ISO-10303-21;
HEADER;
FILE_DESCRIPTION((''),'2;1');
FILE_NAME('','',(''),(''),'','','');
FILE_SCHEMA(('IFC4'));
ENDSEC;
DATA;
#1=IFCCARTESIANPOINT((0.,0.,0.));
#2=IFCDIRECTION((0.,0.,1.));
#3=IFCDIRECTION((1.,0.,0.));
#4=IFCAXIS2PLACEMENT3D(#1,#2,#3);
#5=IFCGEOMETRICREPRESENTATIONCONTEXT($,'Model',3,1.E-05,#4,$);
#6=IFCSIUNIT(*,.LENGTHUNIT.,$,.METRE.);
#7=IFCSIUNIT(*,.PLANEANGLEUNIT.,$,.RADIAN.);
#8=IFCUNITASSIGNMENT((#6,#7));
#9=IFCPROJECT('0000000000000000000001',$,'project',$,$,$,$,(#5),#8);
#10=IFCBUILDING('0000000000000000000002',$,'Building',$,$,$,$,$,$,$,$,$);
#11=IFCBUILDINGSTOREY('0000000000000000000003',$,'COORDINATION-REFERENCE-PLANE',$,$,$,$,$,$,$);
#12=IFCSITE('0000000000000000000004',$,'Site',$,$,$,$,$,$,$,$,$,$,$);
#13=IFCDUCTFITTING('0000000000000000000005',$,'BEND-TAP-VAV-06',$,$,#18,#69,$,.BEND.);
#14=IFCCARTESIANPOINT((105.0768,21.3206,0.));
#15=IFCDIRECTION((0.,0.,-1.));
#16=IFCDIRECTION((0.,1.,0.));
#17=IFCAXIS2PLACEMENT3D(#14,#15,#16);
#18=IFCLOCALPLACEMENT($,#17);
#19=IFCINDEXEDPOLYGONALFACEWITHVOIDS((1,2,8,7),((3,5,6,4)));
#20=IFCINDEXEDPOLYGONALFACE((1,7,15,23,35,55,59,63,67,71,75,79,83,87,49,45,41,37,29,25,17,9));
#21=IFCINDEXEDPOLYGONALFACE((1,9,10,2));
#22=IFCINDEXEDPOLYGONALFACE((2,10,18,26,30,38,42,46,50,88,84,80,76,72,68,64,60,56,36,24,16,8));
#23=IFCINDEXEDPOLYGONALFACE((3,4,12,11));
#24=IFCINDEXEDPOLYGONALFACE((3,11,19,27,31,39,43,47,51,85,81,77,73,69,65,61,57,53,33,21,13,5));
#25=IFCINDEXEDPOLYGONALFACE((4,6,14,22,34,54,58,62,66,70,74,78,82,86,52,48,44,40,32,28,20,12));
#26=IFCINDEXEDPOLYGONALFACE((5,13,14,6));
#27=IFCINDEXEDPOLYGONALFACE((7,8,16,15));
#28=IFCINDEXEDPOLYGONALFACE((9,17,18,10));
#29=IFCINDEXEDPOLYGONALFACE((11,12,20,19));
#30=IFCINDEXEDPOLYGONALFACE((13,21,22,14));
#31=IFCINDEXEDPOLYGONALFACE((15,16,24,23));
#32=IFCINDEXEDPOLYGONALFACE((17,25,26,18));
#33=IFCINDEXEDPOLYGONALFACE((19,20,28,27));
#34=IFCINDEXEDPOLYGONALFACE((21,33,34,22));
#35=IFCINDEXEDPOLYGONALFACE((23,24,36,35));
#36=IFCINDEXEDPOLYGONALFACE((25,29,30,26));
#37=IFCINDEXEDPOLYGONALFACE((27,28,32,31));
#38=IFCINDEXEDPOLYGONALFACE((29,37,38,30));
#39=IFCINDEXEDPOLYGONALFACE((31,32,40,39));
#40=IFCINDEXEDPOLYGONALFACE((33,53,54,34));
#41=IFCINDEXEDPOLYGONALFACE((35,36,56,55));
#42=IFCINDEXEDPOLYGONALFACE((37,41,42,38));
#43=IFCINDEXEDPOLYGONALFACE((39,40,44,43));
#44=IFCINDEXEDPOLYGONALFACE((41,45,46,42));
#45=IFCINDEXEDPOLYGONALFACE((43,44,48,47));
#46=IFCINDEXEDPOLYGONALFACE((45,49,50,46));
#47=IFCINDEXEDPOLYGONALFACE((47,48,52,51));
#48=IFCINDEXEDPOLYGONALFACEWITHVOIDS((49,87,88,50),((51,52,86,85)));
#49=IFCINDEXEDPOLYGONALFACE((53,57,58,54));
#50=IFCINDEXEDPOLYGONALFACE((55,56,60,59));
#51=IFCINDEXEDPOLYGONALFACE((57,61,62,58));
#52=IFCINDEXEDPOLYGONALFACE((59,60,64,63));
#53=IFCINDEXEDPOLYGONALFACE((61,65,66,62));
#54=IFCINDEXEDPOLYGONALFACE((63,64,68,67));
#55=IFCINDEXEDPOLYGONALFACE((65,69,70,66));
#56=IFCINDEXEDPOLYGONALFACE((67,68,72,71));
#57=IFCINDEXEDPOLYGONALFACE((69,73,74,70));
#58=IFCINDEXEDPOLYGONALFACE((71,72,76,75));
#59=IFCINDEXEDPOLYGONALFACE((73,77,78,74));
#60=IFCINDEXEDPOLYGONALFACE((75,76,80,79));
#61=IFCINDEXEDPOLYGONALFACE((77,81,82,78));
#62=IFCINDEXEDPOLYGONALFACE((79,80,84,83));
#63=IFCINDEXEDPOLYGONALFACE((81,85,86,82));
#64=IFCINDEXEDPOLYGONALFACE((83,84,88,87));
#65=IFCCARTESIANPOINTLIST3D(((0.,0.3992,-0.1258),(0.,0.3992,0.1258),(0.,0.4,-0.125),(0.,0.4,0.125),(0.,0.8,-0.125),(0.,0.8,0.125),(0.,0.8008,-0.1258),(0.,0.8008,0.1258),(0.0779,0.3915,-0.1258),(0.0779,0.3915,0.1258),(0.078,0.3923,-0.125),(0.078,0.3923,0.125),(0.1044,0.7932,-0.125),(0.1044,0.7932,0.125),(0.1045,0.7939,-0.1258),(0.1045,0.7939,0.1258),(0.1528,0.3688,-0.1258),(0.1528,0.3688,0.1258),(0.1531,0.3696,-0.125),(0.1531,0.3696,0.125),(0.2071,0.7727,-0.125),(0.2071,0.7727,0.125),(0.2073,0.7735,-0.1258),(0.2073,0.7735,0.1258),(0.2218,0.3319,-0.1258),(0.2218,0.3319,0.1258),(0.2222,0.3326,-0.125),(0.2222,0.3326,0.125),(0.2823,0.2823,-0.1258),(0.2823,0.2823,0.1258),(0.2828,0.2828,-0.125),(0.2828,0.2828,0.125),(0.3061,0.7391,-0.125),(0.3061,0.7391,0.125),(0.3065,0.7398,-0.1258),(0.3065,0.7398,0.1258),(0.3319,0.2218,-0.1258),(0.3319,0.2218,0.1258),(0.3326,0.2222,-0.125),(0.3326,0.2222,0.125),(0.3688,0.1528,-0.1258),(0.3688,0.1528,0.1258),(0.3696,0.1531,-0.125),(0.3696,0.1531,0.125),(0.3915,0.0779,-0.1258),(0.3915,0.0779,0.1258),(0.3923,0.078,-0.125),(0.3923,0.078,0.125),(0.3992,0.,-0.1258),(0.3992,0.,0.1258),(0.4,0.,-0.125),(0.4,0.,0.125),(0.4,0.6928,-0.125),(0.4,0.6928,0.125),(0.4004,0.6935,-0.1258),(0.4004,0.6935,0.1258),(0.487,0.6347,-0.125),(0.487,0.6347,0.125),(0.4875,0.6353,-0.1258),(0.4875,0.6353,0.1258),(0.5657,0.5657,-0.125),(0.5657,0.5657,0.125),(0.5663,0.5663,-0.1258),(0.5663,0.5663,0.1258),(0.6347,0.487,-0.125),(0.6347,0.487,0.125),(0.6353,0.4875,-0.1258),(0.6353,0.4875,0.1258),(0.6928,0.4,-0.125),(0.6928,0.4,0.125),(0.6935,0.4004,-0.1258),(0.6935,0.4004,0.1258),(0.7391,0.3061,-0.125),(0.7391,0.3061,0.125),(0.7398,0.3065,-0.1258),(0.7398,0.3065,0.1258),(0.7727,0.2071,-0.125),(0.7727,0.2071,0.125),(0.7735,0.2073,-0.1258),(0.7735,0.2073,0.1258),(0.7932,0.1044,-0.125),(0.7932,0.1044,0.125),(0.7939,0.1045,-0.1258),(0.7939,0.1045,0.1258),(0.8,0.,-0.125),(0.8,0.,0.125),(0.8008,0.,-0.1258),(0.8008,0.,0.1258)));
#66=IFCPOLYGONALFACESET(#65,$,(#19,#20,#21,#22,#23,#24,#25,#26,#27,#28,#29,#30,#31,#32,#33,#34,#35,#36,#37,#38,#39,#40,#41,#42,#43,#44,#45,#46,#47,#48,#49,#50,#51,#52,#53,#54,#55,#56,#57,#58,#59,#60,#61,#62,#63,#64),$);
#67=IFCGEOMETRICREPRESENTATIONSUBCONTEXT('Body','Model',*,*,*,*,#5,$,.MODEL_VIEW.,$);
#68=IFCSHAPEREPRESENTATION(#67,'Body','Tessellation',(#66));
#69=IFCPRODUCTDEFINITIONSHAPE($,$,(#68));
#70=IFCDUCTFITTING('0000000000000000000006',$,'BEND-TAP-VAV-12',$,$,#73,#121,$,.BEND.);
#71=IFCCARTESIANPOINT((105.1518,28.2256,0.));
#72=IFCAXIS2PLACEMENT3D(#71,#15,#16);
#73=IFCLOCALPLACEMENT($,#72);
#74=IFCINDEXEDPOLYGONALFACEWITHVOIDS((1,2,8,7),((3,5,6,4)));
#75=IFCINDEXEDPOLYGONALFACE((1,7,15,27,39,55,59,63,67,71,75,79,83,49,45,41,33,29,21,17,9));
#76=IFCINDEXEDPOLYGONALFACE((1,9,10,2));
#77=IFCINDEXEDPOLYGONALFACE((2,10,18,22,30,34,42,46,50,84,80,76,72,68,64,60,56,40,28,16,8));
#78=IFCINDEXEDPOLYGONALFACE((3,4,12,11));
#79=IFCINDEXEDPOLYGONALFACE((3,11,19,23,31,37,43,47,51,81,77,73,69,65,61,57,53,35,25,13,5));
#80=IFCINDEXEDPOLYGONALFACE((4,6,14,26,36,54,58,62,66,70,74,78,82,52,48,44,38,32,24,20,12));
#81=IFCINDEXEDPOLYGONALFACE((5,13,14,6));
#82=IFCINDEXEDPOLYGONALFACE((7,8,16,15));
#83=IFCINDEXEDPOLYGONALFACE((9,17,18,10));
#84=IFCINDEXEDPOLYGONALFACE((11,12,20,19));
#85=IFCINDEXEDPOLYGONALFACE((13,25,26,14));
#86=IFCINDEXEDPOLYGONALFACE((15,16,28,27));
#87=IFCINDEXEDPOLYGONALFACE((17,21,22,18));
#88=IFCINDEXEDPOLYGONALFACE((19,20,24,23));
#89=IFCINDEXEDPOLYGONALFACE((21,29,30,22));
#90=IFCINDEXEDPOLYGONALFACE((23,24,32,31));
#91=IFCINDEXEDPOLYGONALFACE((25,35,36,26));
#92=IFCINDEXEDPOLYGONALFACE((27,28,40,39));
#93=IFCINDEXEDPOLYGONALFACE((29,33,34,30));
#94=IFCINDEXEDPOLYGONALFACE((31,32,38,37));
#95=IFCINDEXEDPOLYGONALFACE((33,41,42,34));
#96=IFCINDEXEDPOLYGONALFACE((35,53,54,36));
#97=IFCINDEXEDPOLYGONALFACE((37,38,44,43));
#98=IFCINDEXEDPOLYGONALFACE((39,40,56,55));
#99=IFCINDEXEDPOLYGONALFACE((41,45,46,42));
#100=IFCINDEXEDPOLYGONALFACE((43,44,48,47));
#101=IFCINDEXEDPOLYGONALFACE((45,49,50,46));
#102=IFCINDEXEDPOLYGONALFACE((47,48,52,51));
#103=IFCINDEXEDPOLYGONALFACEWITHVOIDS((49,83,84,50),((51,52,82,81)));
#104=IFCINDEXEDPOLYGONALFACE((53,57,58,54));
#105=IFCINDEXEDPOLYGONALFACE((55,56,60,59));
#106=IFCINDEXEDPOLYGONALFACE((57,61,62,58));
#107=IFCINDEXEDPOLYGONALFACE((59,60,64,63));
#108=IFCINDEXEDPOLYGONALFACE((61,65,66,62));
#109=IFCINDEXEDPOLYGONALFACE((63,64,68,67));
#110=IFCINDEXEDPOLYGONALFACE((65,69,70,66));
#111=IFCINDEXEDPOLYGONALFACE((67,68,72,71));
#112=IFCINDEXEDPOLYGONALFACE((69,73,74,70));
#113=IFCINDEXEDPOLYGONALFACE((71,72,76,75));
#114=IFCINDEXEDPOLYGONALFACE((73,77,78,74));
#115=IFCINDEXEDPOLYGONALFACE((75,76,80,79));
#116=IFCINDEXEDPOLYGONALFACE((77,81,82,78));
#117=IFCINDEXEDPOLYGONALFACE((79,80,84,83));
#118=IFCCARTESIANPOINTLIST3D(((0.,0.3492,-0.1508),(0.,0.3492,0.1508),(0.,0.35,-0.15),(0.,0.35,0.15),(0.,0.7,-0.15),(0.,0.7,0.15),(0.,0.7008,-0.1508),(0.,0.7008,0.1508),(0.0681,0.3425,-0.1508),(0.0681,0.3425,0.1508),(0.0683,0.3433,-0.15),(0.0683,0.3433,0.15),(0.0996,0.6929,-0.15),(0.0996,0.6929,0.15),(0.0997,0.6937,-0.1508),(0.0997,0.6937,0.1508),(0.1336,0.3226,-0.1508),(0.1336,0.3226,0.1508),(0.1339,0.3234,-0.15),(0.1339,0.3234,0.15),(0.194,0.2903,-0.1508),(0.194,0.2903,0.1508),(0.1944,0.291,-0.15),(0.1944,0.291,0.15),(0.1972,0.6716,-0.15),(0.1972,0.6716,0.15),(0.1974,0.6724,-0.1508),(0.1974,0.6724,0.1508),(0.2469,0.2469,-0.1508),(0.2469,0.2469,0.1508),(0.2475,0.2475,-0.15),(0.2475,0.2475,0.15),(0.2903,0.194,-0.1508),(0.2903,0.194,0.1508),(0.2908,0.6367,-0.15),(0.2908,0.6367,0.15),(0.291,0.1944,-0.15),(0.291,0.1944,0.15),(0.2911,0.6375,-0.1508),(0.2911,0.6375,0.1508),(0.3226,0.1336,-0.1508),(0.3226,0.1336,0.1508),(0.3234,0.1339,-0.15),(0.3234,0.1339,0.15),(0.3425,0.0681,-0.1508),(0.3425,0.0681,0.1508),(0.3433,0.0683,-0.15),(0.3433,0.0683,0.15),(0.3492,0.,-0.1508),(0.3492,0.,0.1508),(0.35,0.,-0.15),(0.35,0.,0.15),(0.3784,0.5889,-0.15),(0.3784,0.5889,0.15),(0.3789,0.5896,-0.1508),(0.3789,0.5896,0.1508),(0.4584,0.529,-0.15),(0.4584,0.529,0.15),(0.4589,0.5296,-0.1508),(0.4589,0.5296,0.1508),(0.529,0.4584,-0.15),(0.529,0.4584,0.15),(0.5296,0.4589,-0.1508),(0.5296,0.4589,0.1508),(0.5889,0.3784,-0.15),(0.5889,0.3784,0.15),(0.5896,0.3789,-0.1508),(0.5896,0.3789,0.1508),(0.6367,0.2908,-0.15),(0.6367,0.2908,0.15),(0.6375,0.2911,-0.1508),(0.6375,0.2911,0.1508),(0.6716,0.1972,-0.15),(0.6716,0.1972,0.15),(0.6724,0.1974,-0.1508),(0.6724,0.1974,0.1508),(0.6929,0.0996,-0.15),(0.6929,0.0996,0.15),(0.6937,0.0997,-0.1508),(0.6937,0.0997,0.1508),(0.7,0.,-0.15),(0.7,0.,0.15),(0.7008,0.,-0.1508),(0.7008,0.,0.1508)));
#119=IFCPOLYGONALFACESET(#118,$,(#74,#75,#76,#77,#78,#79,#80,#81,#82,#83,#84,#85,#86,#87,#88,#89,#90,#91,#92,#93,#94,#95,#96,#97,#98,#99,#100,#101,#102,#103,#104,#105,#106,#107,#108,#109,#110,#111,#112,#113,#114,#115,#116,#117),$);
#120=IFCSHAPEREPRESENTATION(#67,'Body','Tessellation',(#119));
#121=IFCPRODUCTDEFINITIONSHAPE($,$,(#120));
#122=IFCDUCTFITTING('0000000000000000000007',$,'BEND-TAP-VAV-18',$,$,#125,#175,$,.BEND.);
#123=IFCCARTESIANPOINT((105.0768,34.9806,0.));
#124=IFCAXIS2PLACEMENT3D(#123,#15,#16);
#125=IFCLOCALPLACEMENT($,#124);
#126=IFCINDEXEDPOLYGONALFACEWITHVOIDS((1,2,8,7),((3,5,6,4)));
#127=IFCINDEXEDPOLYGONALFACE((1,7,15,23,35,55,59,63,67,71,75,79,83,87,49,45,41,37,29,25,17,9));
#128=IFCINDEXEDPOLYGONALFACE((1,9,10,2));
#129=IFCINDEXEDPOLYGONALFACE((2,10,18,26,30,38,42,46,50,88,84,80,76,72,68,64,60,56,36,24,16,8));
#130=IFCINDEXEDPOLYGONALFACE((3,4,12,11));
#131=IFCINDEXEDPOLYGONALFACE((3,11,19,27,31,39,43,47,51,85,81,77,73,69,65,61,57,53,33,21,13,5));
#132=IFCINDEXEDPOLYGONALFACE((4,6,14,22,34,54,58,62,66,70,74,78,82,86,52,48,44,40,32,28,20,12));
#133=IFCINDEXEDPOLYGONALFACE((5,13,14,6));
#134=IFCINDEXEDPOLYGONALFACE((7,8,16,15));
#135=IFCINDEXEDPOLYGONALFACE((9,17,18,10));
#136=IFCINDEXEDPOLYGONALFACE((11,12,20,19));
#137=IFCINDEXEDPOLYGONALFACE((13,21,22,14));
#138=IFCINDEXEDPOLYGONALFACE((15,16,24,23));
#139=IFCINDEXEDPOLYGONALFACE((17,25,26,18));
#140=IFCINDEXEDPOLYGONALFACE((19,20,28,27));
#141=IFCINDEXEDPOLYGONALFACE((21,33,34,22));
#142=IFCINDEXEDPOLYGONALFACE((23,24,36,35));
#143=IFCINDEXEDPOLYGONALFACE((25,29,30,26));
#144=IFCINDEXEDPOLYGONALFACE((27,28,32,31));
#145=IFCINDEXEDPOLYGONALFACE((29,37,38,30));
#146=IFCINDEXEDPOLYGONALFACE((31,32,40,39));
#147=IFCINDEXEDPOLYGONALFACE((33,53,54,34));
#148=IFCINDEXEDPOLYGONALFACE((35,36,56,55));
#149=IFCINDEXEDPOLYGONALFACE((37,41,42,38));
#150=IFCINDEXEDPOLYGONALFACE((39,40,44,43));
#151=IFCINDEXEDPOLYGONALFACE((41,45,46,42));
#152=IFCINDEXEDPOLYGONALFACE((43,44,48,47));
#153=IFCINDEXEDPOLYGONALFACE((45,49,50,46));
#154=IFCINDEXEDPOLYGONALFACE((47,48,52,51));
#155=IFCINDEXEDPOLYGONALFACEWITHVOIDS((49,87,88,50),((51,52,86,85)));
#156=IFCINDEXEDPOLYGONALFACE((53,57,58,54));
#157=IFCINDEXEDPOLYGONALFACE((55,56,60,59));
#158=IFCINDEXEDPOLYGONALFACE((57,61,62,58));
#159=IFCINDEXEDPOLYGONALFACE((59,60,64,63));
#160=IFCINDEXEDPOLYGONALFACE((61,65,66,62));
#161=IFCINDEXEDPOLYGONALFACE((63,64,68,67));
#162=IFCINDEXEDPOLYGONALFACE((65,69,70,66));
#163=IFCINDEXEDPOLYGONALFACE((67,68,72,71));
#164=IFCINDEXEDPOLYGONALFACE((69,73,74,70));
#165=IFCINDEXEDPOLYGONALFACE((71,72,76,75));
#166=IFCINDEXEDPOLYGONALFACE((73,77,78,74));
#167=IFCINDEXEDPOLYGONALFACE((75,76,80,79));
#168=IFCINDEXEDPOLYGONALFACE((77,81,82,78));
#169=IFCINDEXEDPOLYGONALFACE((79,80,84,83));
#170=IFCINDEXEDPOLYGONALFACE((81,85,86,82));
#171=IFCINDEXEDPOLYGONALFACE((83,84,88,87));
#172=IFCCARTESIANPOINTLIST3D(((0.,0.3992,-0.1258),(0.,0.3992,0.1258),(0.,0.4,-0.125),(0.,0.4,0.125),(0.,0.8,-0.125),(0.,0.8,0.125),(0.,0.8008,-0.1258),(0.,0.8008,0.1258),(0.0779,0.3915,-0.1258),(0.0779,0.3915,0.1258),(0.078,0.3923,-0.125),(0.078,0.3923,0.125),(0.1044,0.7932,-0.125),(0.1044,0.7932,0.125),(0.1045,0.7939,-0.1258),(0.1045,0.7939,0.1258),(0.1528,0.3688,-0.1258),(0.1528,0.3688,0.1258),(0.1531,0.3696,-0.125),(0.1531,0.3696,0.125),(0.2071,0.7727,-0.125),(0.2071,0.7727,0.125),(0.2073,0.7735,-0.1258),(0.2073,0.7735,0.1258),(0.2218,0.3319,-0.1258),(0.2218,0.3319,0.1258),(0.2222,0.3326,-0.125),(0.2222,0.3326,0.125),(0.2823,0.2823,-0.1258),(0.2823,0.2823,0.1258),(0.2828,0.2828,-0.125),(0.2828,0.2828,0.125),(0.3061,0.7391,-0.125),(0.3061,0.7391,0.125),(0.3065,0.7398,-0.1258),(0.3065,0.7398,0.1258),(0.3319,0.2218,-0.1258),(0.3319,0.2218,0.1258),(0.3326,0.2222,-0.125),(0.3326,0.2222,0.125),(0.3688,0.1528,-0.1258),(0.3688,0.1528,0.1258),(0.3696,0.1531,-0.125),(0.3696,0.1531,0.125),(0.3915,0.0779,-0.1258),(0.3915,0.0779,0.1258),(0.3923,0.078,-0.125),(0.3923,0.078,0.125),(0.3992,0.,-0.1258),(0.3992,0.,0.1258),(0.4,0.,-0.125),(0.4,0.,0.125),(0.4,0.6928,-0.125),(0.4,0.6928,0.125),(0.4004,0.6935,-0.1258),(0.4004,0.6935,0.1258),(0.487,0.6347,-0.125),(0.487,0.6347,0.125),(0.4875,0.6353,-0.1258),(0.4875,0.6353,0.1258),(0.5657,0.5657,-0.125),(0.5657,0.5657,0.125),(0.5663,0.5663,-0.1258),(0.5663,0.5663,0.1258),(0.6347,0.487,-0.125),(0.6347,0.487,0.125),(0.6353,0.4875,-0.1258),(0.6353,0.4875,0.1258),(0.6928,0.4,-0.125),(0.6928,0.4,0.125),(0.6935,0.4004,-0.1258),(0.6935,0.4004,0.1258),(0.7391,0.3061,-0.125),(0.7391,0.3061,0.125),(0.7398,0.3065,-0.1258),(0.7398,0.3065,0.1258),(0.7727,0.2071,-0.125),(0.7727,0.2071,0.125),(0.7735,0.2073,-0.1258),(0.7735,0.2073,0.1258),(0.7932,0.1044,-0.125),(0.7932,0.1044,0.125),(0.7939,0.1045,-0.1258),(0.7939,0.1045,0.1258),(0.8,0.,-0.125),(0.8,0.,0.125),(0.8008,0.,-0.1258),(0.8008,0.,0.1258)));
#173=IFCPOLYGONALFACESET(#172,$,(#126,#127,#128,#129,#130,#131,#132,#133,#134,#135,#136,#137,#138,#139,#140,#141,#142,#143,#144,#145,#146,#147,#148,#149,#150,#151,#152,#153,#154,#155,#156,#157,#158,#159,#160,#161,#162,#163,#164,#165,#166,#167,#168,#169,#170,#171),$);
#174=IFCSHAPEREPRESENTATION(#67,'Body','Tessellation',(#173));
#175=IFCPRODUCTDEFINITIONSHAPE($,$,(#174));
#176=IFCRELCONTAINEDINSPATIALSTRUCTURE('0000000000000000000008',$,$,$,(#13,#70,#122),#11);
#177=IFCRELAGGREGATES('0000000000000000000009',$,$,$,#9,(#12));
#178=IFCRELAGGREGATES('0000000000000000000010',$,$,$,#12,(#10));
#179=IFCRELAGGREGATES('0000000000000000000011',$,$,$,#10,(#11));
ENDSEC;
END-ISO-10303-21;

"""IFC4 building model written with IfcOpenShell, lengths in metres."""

from ifc_helpers import new_model, entity, si_unit, frame, origin_with_axes, place, context, subcontext, project, spatial, element, save


model = new_model("IFC4")

# Units and contexts
model_context = context("Model", 3, precision=1e-05, world=origin_with_axes())
body_context = subcontext(model_context, "Body", "Model", "MODEL_VIEW")
ifc_project = project(units=[si_unit("LENGTHUNIT", "METRE"), si_unit("PLANEANGLEUNIT", "RADIAN")], contexts=[model_context])

# Site, building, storey
site = spatial("IfcSite", under=ifc_project, Name="Site")
building = spatial("IfcBuilding", under=site, Name="Building")
storey = spatial("IfcBuildingStorey", under=building, Name="COORDINATION-REFERENCE-PLANE")

# Duct fittings
duct_fitting_1_placement = place(None, frame((105.0768, 21.3206, 0.0), z_axis=(0.0, 0.0, -1.0), x_axis=(0.0, 1.0, 0.0)))
cartesian_point_1 = entity("IfcCartesianPoint", [0.0, 0.0, 0.0])
element("IfcDuctFitting", 1, at=duct_fitting_1_placement, inside=storey, Name="BEND-TAP-VAV-06", PredefinedType="BEND", context=body_context, shape_type="SweptSolid", body=[
    entity("IfcRevolvedAreaSolid", entity("IfcRectangleHollowProfileDef", "AREA", None, entity("IfcAxis2Placement2D", entity("IfcCartesianPoint", [0.6, 0.0])), 0.4016, 0.2516, 0.0008), entity("IfcAxis2Placement3D", cartesian_point_1, entity("IfcDirection", [0.0, -1.0, 0.0]), entity("IfcDirection", [1.0, 0.0, 0.0])), entity("IfcAxis1Placement", cartesian_point_1, entity("IfcDirection", [0.0, 1.0, 0.0])), 1.570796),
])
duct_fitting_2_placement = place(None, frame((105.1518, 28.2256, 0.0), z_axis=(0.0, 0.0, -1.0), x_axis=(0.0, 1.0, 0.0)))
cartesian_point_2 = entity("IfcCartesianPoint", [0.0, 0.0, 0.0])
element("IfcDuctFitting", 2, at=duct_fitting_2_placement, inside=storey, Name="BEND-TAP-VAV-12", PredefinedType="BEND", context=body_context, shape_type="SweptSolid", body=[
    entity("IfcRevolvedAreaSolid", entity("IfcRectangleHollowProfileDef", "AREA", None, entity("IfcAxis2Placement2D", entity("IfcCartesianPoint", [0.525, 0.0])), 0.3516, 0.3016, 0.0008), entity("IfcAxis2Placement3D", cartesian_point_2, entity("IfcDirection", [0.0, -1.0, 0.0]), entity("IfcDirection", [1.0, 0.0, 0.0])), entity("IfcAxis1Placement", cartesian_point_2, entity("IfcDirection", [0.0, 1.0, 0.0])), 1.570796),
])
duct_fitting_3_placement = place(None, frame((105.0768, 34.9806, 0.0), z_axis=(0.0, 0.0, -1.0), x_axis=(0.0, 1.0, 0.0)))
cartesian_point_3 = entity("IfcCartesianPoint", [0.0, 0.0, 0.0])
element("IfcDuctFitting", 3, at=duct_fitting_3_placement, inside=storey, Name="BEND-TAP-VAV-18", PredefinedType="BEND", context=body_context, shape_type="SweptSolid", body=[
    entity("IfcRevolvedAreaSolid", entity("IfcRectangleHollowProfileDef", "AREA", None, entity("IfcAxis2Placement2D", entity("IfcCartesianPoint", [0.6, 0.0])), 0.4016, 0.2516, 0.0008), entity("IfcAxis2Placement3D", cartesian_point_3, entity("IfcDirection", [0.0, -1.0, 0.0]), entity("IfcDirection", [1.0, 0.0, 0.0])), entity("IfcAxis1Placement", cartesian_point_3, entity("IfcDirection", [0.0, 1.0, 0.0])), 1.570796),
])

save(model, "model.ifc")
